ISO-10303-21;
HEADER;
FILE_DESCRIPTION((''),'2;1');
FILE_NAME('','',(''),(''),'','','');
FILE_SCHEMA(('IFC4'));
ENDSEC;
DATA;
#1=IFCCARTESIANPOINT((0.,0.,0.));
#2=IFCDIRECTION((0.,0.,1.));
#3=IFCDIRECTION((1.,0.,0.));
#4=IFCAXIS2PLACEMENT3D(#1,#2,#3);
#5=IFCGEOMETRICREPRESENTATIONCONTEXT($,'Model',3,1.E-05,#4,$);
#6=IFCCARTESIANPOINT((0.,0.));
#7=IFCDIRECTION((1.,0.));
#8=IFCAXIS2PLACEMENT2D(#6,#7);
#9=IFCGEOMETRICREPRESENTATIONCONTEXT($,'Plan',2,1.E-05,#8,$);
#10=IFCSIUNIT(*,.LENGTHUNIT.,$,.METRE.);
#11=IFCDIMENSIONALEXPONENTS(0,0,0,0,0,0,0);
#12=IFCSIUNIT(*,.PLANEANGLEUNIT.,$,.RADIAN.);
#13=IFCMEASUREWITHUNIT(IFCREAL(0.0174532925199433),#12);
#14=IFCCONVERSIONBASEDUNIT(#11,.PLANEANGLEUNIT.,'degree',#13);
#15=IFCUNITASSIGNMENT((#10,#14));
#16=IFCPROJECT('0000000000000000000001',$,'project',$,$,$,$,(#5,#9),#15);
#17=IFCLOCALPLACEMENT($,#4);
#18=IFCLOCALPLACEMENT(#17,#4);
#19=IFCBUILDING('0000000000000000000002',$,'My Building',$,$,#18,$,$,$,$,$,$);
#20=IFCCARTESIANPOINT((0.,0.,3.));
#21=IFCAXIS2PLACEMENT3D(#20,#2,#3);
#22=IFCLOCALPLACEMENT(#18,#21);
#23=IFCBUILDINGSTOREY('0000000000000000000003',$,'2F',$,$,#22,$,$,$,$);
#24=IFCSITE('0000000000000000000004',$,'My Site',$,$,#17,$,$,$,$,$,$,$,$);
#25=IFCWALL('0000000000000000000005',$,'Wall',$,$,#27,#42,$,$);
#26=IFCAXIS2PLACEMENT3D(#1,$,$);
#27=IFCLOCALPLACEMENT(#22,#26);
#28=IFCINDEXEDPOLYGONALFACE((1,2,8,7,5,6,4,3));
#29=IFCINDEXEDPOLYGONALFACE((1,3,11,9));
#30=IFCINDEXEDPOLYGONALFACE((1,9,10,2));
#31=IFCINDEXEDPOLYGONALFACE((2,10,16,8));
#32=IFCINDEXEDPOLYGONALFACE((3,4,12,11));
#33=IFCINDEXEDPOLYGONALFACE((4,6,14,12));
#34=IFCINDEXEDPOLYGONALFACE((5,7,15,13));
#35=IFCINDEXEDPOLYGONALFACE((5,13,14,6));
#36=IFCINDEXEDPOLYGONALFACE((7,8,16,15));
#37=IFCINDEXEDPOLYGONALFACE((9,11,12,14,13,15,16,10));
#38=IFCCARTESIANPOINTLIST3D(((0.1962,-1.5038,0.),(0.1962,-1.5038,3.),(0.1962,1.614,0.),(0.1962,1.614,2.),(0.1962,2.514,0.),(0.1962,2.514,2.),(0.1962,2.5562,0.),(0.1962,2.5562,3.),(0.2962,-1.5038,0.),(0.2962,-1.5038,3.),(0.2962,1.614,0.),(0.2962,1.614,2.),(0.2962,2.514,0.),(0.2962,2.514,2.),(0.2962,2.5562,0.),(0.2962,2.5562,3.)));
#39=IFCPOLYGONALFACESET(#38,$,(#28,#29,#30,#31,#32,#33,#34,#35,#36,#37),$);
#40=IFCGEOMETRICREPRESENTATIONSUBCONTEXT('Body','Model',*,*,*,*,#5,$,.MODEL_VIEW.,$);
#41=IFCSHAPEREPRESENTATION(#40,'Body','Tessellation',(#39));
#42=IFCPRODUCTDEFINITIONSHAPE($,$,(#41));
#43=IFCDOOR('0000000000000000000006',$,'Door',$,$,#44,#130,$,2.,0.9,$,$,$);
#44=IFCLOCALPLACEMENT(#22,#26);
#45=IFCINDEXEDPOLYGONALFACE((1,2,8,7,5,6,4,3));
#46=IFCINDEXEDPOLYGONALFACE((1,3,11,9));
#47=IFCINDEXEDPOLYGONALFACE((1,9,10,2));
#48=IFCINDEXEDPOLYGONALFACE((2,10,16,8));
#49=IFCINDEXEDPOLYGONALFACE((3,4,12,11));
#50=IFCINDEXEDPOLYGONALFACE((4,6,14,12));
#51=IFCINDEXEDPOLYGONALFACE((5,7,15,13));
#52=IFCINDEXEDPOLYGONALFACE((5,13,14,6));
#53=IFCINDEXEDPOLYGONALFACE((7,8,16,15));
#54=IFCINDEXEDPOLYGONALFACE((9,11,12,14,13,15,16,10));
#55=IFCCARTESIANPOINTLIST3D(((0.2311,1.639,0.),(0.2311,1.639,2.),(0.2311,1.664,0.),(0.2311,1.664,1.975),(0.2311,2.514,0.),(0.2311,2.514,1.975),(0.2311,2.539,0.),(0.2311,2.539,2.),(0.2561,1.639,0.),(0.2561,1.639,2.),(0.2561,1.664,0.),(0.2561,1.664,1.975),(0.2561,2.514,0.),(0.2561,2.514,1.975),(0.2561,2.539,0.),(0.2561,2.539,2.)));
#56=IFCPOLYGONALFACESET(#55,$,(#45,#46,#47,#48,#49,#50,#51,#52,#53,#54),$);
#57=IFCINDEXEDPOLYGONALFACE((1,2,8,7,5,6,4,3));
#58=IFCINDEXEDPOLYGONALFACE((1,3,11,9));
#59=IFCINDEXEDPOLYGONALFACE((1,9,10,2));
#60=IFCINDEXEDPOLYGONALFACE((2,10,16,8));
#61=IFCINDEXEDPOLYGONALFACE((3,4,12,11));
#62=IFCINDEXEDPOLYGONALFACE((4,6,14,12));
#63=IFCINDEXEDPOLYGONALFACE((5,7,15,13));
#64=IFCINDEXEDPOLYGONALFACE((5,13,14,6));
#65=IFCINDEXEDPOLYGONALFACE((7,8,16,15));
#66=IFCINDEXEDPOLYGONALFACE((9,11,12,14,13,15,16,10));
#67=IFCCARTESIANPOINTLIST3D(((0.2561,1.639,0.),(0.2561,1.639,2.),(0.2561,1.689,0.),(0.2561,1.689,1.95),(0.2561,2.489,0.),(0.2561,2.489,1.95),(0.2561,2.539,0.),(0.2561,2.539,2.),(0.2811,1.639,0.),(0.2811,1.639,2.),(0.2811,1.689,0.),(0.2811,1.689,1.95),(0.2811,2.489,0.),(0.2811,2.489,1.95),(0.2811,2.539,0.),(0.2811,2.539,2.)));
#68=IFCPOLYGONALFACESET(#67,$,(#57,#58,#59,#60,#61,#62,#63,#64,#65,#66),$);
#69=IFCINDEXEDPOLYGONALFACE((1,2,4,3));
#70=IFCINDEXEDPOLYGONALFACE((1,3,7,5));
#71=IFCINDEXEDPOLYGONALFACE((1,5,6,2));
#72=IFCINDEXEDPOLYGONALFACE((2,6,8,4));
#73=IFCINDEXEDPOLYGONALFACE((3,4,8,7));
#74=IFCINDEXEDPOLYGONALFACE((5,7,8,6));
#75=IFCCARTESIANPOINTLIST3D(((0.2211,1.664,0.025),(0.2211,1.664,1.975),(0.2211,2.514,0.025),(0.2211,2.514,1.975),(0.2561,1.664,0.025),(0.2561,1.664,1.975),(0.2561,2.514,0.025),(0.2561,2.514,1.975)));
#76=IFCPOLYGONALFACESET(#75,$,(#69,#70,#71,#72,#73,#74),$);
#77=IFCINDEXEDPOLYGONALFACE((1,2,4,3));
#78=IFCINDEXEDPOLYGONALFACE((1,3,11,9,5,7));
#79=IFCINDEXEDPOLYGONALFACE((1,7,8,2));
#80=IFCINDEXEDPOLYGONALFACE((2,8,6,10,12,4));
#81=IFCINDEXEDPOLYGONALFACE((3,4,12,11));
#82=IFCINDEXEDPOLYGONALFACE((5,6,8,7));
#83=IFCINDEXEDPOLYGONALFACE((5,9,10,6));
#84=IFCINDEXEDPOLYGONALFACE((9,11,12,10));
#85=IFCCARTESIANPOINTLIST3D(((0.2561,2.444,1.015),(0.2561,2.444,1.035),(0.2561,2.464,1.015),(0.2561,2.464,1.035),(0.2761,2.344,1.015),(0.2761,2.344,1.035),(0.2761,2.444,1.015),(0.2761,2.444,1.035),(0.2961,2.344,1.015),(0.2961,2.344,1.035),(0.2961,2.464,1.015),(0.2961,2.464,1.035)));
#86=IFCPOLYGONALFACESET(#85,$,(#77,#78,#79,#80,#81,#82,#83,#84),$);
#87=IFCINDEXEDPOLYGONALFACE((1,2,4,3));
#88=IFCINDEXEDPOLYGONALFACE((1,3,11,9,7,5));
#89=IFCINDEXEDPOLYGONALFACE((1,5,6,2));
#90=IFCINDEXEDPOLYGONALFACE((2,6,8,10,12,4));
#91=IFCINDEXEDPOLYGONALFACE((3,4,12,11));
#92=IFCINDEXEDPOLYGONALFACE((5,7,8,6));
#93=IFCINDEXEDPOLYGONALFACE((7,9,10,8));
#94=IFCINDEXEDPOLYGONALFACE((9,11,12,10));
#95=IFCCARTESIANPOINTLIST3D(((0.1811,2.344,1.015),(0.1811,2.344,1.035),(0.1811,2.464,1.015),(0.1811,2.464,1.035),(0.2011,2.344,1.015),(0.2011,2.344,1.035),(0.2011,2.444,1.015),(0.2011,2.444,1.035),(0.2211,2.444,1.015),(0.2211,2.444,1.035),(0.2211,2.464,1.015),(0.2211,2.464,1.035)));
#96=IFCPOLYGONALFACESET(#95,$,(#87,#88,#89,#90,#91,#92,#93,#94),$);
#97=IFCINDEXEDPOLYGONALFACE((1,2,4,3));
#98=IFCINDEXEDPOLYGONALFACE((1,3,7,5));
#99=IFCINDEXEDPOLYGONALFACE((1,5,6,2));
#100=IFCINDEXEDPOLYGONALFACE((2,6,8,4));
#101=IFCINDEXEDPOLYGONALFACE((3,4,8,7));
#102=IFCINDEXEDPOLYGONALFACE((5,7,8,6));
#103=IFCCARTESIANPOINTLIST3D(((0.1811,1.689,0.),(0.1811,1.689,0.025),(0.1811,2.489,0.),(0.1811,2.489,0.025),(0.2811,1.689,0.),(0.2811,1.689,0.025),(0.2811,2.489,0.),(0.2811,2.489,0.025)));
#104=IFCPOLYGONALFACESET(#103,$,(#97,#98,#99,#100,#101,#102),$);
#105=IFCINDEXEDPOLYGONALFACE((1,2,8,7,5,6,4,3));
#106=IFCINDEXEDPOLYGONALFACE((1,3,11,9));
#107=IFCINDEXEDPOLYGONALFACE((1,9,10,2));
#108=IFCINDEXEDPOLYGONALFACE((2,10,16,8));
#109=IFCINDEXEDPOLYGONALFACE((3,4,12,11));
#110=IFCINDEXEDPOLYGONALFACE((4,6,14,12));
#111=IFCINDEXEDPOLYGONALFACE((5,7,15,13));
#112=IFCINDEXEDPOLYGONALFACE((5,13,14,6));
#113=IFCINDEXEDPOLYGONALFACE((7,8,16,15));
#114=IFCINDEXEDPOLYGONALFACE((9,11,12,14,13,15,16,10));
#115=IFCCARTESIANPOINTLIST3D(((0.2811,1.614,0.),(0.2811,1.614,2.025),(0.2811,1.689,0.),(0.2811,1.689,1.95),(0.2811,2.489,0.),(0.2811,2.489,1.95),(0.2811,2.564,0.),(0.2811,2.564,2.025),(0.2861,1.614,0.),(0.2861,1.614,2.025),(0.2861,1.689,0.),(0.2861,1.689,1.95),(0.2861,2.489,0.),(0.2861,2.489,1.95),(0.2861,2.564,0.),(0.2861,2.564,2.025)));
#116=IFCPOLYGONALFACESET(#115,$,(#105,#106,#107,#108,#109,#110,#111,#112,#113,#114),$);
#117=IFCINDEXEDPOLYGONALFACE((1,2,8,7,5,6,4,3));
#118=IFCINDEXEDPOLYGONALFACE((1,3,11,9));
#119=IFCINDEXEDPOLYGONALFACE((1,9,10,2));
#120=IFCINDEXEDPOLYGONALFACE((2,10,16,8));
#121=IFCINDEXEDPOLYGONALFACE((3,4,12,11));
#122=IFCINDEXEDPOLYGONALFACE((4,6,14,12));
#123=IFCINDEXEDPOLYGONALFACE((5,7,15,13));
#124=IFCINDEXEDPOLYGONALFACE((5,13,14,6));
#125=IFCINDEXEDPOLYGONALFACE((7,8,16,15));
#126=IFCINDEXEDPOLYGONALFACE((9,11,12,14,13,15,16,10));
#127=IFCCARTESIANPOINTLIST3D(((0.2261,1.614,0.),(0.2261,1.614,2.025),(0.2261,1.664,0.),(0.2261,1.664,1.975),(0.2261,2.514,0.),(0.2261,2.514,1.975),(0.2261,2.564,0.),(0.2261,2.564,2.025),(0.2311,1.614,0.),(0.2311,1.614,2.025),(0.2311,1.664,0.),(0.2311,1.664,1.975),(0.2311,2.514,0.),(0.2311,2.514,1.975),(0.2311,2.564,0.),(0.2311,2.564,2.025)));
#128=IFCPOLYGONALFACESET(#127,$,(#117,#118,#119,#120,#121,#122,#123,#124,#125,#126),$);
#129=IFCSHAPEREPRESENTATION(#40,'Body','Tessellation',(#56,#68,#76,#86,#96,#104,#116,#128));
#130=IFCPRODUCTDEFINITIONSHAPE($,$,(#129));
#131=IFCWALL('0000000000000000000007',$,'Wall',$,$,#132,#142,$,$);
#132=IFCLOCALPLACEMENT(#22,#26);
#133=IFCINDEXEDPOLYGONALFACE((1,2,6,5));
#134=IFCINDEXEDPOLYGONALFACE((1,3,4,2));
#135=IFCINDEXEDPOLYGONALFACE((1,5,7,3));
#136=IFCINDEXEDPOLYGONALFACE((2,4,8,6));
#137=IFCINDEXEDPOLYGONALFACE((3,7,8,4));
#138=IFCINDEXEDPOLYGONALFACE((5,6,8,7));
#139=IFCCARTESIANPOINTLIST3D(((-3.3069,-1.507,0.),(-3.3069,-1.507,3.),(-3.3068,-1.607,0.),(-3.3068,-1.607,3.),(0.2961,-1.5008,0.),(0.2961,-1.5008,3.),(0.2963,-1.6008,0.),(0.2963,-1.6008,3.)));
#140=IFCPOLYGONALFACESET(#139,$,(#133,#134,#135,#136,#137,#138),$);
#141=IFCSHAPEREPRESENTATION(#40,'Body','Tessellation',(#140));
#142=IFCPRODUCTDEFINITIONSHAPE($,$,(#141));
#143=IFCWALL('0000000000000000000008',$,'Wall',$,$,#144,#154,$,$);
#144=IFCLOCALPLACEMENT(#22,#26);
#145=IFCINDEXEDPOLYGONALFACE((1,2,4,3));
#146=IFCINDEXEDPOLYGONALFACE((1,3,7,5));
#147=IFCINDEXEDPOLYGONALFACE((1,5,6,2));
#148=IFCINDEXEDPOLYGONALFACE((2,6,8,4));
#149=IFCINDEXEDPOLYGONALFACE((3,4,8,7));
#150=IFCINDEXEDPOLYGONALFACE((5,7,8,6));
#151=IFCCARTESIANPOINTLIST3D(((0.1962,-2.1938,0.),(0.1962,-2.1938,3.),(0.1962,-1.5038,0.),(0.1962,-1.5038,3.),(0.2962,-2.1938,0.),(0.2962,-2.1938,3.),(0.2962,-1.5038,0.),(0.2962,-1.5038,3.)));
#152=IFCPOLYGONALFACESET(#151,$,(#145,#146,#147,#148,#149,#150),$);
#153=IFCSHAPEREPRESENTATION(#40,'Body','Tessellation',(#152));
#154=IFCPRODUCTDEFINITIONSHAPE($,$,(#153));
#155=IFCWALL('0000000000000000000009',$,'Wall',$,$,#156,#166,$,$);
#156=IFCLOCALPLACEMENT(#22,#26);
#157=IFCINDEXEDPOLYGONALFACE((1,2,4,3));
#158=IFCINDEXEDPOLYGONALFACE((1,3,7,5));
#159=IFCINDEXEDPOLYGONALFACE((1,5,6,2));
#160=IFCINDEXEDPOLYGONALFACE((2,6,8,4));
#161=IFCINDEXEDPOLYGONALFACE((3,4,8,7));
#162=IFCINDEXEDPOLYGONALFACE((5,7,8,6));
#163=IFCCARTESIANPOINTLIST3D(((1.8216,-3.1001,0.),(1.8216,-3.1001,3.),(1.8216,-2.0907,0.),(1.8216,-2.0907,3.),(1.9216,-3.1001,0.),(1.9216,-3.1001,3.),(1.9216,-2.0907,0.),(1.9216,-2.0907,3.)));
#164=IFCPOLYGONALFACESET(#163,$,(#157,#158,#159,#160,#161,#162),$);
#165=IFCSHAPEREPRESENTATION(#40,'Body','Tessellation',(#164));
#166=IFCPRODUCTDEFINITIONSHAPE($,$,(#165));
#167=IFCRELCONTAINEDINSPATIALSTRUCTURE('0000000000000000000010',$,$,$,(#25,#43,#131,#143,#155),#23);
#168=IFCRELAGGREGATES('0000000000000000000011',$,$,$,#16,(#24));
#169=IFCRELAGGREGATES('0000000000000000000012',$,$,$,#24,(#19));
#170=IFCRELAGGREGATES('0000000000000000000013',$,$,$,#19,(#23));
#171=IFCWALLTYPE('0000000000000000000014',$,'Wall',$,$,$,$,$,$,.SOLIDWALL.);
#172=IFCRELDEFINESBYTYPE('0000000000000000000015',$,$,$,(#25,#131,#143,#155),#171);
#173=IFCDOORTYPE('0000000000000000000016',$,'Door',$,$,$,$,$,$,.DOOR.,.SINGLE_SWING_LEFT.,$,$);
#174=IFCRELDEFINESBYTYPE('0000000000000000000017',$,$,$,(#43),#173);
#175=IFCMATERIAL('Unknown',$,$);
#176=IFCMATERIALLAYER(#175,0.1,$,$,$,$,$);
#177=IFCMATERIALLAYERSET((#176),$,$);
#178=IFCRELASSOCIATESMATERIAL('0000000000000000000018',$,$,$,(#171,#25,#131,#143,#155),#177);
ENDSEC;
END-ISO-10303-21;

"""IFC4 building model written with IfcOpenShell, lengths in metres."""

from ifc_helpers import new_model, entity, si_unit, converted_unit, frame, origin_with_axes, origin_2d_with_axis, place, context, subcontext, project, spatial, line, indexed_curve, outline, extrude, shape, source, transform, mapped, material, layer, layer_set, layer_usage, type_object, type_shapes, element, fill, save


model = new_model("IFC4")

# Units and contexts
model_context = context("Model", 3, precision=1e-05, world=origin_with_axes())
plan_context = context("Plan", 2, precision=1e-05, world=origin_2d_with_axis())
body_context_1 = subcontext(model_context, "Body", "Model", "MODEL_VIEW")
body_context_2 = subcontext(plan_context, "Body", "Plan", "PLAN_VIEW")
ifc_project = project(units=[si_unit("LENGTHUNIT", "METRE"), converted_unit("PLANEANGLEUNIT", "degree", entity("IfcReal", 0.0174532925199433), si_unit("PLANEANGLEUNIT", "RADIAN"), dimensions=[0, 0, 0, 0, 0, 0, 0])], contexts=[model_context, plan_context])

# Site, building, storey
site_placement = place(None, origin_with_axes())
site = spatial("IfcSite", under=ifc_project, at=site_placement, Name="My Site")
building_placement = place(site_placement, origin_with_axes())
building = spatial("IfcBuilding", under=site, at=building_placement, Name="My Building")
storey_placement = place(building_placement, frame((0.0, 0.0, 3.0), z_axis=(0.0, 0.0, 1.0), x_axis=(1.0, 0.0, 0.0)))
storey = spatial("IfcBuildingStorey", under=building, at=storey_placement, Name="2F")

# Shared definitions
ifc_material = material(Name="Unknown")

# Shared definitions
ifc_layer_1 = layer(ifc_material, 0.1)
ifc_layer_set_1 = layer_set([ifc_layer_1])
wall_type = type_object("IfcWallType", Name="Wall", PredefinedType="SOLIDWALL", material=ifc_layer_set_1)

# Wall, opening, door
ifc_layer_usage_1 = layer_usage(ifc_layer_set_1, "AXIS2", "POSITIVE", 0.0)
wall_1_placement = place(storey_placement, frame((0.2962, -1.5038, 0.0), z_axis=(0.0, 0.0, 1.0), x_axis=(0.0, 1.0, 0.0)))
wall_1 = element("IfcWall", 1, at=wall_1_placement, inside=storey, type_object=wall_type, material=ifc_layer_usage_1, Name="Wall", context=body_context_1, shape_type="SweptSolid", body=[
    extrude(outline(indexed_curve([(0.0, 0.0), (0.0, 0.1), (4.06, 0.1), (4.06, 0.0)], segments=[line(1, 2, 3, 4, 1)])), origin_with_axes(), (0.0, 0.0, 1.0), 3.0),
])
shared_shape_1 = source(origin_with_axes(), body_context_1, "Body", "SweptSolid", [
    extrude(outline(indexed_curve([(0.0, 0.0), (0.9, 0.0), (0.9, 2.0), (0.0, 2.0)], segments=[line(1, 2, 3, 4, 1)])), frame((0.0, -0.6, 0.0), z_axis=(0.0, -1.0, 0.0), x_axis=(1.0, 0.0, 0.0)), (0.0, 0.0, -1.0), 1.2),
])
opening_1_placement = place(wall_1_placement, frame((3.1178, 0.0, 0.0), z_axis=(0.0, 0.0, 1.0), x_axis=(1.0, 0.0, 0.0)))
opening_1 = element("IfcOpeningElement", 2, at=opening_1_placement, cuts=wall_1, PredefinedType="OPENING", context=body_context_1, shape_type="MappedRepresentation", body=[
    mapped(shared_shape_1, transform((0.0, 0.0, 0.0), x_axis=(1.0, 0.0, 0.0), y_axis=(0.0, 1.0, 0.0), z_axis=(0.0, 0.0, 1.0), scale=1.0)),
])
door_type_1 = type_object("IfcDoorType", Name="Door", OperationType="SINGLE_SWING_LEFT", PredefinedType="DOOR")
shared_shape_2 = source(origin_with_axes(), body_context_1, "Body", "SweptSolid", [
    extrude(outline(indexed_curve([(0.0, 0.0), (0.0, 2.0), (0.9, 2.0), (0.9, 0.0), (0.875, 0.0), (0.875, 1.975), (0.025, 1.975), (0.025, 0.0)], segments=[line(1, 2, 3, 4, 5, 6, 7, 8, 1)])), frame((0.0, 0.025, 0.0), z_axis=(0.0, -1.0, 0.0), x_axis=(1.0, 0.0, 0.0)), (0.0, 0.0, -1.0), 0.025),
    extrude(outline(indexed_curve([(0.0, 0.0), (0.0, 2.0), (0.9, 2.0), (0.9, 0.0), (0.85, 0.0), (0.85, 1.95), (0.05, 1.95), (0.05, 0.0)], segments=[line(1, 2, 3, 4, 5, 6, 7, 8, 1)])), frame((0.0, 0.0, 0.0), z_axis=(0.0, -1.0, 0.0), x_axis=(1.0, 0.0, 0.0)), (0.0, 0.0, -1.0), 0.025),
    extrude(outline(indexed_curve([(0.0, 0.0), (0.85, 0.0), (0.85, 0.035), (0.0, 0.035)], segments=[line(1, 2, 3, 4, 1)])), frame((0.025, 0.025, 0.025), z_axis=(0.0, 0.0, 1.0), x_axis=(1.0, 0.0, 0.0)), (0.0, 0.0, 1.0), 1.95),
    extrude(outline(indexed_curve([(0.0, 0.0), (0.0, -0.04), (-0.12, -0.04), (-0.12, -0.02), (-0.02, -0.02), (-0.02, 0.0)], segments=[line(1, 2, 3, 4, 5, 6, 1)])), frame((0.825, 0.025, 1.015), z_axis=(0.0, 0.0, 1.0), x_axis=(1.0, 0.0, 0.0)), (0.0, 0.0, 1.0), 0.02),
    extrude(outline(indexed_curve([(0.0, 0.0), (0.0, 0.04), (-0.12, 0.04), (-0.12, 0.02), (-0.02, 0.02), (-0.02, 0.0)], segments=[line(1, 2, 3, 4, 5, 6, 1)])), frame((0.825, 0.06, 1.015), z_axis=(0.0, 0.0, 1.0), x_axis=(1.0, 0.0, 0.0)), (0.0, 0.0, 1.0), 0.02),
    extrude(outline(indexed_curve([(0.0, 0.0), (0.8, 0.0), (0.8, 0.1), (0.0, 0.1)], segments=[line(1, 2, 3, 4, 1)])), frame((0.05, 0.0, 0.0), z_axis=(0.0, 0.0, 1.0), x_axis=(1.0, 0.0, 0.0)), (0.0, 0.0, 1.0), 0.025),
    extrude(outline(indexed_curve([(0.0, 0.0), (0.0, 2.025), (0.95, 2.025), (0.95, 0.0), (0.875, 0.0), (0.875, 1.95), (0.075, 1.95), (0.075, 0.0)], segments=[line(1, 2, 3, 4, 5, 6, 7, 8, 1)])), frame((-0.025, -0.005, 0.0), z_axis=(0.0, -1.0, 0.0), x_axis=(1.0, 0.0, 0.0)), (0.0, 0.0, -1.0), 0.005),
    extrude(outline(indexed_curve([(0.0, 0.0), (0.0, 2.025), (0.95, 2.025), (0.95, 0.0), (0.9, 0.0), (0.9, 1.975), (0.05, 1.975), (0.05, 0.0)], segments=[line(1, 2, 3, 4, 5, 6, 7, 8, 1)])), frame((-0.025, 0.05, 0.0), z_axis=(0.0, -1.0, 0.0), x_axis=(1.0, 0.0, 0.0)), (0.0, 0.0, -1.0), 0.005),
])
shared_shape_3 = source(origin_with_axes(), body_context_2, "Body", "Curve2D", [
    entity("IfcIndexedPolyCurve", entity("IfcCartesianPointList2D", [[0.0, 0.0], [0.0, 0.05], [0.025, 0.05], [0.025, 0.025], [0.05, 0.025], [0.05, 0.0]]), [entity("IfcLineIndex", [1, 2, 3, 4, 5, 6, 1])]),
    entity("IfcIndexedPolyCurve", entity("IfcCartesianPointList2D", [[0.9, 0.0], [0.9, 0.05], [0.875, 0.05], [0.875, 0.025], [0.85, 0.025], [0.85, 0.0]]), [entity("IfcLineIndex", [1, 2, 3, 4, 5, 6, 1])]),
    entity("IfcTrimmedCurve", entity("IfcEllipse", entity("IfcAxis2Placement2D", entity("IfcCartesianPoint", [0.06, 0.05]), entity("IfcDirection", [1.0, 0.0])), 0.815, 0.85), [entity("IfcCartesianPoint", [0.875, 0.05])], [entity("IfcCartesianPoint", [0.06, 0.9])], True, "CARTESIAN"),
    entity("IfcIndexedPolyCurve", entity("IfcCartesianPointList2D", [[0.025, 0.05], [0.06, 0.05], [0.06, 0.9], [0.025, 0.9]]), [entity("IfcLineIndex", [1, 2, 3, 4, 1])]),
])
type_shapes(door_type_1, [shared_shape_2, shared_shape_3])
door_1_placement = place(opening_1_placement, frame((0.025, 0.0151, 0.0), z_axis=(0.0, 0.0, 1.0), x_axis=(1.0, 0.0, 0.0)))
door_1 = element("IfcDoor", 3, at=door_1_placement, inside=storey, type_object=door_type_1, Name="Door", OverallHeight=2.0, OverallWidth=0.9, shapes=[
    shape(body_context_1, "Body", "MappedRepresentation", [mapped(shared_shape_2, transform((0.0, 0.0, 0.0), x_axis=(1.0, 0.0, 0.0), y_axis=(0.0, 1.0, 0.0), z_axis=(0.0, 0.0, 1.0), scale=1.0))]),
    shape(body_context_2, "Body", "MappedRepresentation", [mapped(shared_shape_3, transform((0.0, 0.0, 0.0), x_axis=(1.0, 0.0, 0.0), y_axis=(0.0, 1.0, 0.0), z_axis=(0.0, 0.0, 1.0), scale=1.0))]),
])
fill(opening_1, door_1)

# Walls
ifc_layer_usage_2 = layer_usage(ifc_layer_set_1, "AXIS2", "POSITIVE", 0.0)
wall_2_placement = place(storey_placement, frame((-3.3068, -1.607, 0.0), z_axis=(0.0, 0.0, 1.0), x_axis=(0.999999, 0.001712, 0.0)))
element("IfcWall", 4, at=wall_2_placement, inside=storey, type_object=wall_type, material=ifc_layer_usage_2, Name="Wall", context=body_context_1, shape_type="SweptSolid", body=[
    extrude(outline(indexed_curve([(0.0, 0.0), (0.0, 0.1), (3.6031, 0.1), (3.6031, 0.0)], segments=[line(1, 2, 3, 4, 1)])), origin_with_axes(), (0.0, 0.0, 1.0), 3.0),
])
ifc_layer_usage_3 = layer_usage(ifc_layer_set_1, "AXIS2", "POSITIVE", 0.0)
wall_3_placement = place(storey_placement, frame((0.1962, -1.5038, 0.0), z_axis=(0.0, 0.0, 1.0), x_axis=(0.0, -1.0, 0.0)))
element("IfcWall", 5, at=wall_3_placement, inside=storey, type_object=wall_type, material=ifc_layer_usage_3, Name="Wall", context=body_context_1, shape_type="SweptSolid", body=[
    extrude(outline(indexed_curve([(0.0, 0.0), (0.0, 0.1), (0.69, 0.1), (0.69, 0.0)], segments=[line(1, 2, 3, 4, 1)])), origin_with_axes(), (0.0, 0.0, 1.0), 3.0),
])
ifc_layer_usage_4 = layer_usage(ifc_layer_set_1, "AXIS2", "POSITIVE", 0.0)
wall_4_placement = place(storey_placement, frame((1.9216, -3.1001, 0.0), z_axis=(0.0, 0.0, 1.0), x_axis=(0.000002, 1.0, 0.0)))
element("IfcWall", 6, at=wall_4_placement, inside=storey, type_object=wall_type, material=ifc_layer_usage_4, Name="Wall", context=body_context_1, shape_type="SweptSolid", body=[
    extrude(outline(indexed_curve([(0.0, 0.0), (0.0, 0.1), (1.0094, 0.1), (1.0094, 0.0)], segments=[line(1, 2, 3, 4, 1)])), origin_with_axes(), (0.0, 0.0, 1.0), 3.0),
])

save(model, "model.ifc")
